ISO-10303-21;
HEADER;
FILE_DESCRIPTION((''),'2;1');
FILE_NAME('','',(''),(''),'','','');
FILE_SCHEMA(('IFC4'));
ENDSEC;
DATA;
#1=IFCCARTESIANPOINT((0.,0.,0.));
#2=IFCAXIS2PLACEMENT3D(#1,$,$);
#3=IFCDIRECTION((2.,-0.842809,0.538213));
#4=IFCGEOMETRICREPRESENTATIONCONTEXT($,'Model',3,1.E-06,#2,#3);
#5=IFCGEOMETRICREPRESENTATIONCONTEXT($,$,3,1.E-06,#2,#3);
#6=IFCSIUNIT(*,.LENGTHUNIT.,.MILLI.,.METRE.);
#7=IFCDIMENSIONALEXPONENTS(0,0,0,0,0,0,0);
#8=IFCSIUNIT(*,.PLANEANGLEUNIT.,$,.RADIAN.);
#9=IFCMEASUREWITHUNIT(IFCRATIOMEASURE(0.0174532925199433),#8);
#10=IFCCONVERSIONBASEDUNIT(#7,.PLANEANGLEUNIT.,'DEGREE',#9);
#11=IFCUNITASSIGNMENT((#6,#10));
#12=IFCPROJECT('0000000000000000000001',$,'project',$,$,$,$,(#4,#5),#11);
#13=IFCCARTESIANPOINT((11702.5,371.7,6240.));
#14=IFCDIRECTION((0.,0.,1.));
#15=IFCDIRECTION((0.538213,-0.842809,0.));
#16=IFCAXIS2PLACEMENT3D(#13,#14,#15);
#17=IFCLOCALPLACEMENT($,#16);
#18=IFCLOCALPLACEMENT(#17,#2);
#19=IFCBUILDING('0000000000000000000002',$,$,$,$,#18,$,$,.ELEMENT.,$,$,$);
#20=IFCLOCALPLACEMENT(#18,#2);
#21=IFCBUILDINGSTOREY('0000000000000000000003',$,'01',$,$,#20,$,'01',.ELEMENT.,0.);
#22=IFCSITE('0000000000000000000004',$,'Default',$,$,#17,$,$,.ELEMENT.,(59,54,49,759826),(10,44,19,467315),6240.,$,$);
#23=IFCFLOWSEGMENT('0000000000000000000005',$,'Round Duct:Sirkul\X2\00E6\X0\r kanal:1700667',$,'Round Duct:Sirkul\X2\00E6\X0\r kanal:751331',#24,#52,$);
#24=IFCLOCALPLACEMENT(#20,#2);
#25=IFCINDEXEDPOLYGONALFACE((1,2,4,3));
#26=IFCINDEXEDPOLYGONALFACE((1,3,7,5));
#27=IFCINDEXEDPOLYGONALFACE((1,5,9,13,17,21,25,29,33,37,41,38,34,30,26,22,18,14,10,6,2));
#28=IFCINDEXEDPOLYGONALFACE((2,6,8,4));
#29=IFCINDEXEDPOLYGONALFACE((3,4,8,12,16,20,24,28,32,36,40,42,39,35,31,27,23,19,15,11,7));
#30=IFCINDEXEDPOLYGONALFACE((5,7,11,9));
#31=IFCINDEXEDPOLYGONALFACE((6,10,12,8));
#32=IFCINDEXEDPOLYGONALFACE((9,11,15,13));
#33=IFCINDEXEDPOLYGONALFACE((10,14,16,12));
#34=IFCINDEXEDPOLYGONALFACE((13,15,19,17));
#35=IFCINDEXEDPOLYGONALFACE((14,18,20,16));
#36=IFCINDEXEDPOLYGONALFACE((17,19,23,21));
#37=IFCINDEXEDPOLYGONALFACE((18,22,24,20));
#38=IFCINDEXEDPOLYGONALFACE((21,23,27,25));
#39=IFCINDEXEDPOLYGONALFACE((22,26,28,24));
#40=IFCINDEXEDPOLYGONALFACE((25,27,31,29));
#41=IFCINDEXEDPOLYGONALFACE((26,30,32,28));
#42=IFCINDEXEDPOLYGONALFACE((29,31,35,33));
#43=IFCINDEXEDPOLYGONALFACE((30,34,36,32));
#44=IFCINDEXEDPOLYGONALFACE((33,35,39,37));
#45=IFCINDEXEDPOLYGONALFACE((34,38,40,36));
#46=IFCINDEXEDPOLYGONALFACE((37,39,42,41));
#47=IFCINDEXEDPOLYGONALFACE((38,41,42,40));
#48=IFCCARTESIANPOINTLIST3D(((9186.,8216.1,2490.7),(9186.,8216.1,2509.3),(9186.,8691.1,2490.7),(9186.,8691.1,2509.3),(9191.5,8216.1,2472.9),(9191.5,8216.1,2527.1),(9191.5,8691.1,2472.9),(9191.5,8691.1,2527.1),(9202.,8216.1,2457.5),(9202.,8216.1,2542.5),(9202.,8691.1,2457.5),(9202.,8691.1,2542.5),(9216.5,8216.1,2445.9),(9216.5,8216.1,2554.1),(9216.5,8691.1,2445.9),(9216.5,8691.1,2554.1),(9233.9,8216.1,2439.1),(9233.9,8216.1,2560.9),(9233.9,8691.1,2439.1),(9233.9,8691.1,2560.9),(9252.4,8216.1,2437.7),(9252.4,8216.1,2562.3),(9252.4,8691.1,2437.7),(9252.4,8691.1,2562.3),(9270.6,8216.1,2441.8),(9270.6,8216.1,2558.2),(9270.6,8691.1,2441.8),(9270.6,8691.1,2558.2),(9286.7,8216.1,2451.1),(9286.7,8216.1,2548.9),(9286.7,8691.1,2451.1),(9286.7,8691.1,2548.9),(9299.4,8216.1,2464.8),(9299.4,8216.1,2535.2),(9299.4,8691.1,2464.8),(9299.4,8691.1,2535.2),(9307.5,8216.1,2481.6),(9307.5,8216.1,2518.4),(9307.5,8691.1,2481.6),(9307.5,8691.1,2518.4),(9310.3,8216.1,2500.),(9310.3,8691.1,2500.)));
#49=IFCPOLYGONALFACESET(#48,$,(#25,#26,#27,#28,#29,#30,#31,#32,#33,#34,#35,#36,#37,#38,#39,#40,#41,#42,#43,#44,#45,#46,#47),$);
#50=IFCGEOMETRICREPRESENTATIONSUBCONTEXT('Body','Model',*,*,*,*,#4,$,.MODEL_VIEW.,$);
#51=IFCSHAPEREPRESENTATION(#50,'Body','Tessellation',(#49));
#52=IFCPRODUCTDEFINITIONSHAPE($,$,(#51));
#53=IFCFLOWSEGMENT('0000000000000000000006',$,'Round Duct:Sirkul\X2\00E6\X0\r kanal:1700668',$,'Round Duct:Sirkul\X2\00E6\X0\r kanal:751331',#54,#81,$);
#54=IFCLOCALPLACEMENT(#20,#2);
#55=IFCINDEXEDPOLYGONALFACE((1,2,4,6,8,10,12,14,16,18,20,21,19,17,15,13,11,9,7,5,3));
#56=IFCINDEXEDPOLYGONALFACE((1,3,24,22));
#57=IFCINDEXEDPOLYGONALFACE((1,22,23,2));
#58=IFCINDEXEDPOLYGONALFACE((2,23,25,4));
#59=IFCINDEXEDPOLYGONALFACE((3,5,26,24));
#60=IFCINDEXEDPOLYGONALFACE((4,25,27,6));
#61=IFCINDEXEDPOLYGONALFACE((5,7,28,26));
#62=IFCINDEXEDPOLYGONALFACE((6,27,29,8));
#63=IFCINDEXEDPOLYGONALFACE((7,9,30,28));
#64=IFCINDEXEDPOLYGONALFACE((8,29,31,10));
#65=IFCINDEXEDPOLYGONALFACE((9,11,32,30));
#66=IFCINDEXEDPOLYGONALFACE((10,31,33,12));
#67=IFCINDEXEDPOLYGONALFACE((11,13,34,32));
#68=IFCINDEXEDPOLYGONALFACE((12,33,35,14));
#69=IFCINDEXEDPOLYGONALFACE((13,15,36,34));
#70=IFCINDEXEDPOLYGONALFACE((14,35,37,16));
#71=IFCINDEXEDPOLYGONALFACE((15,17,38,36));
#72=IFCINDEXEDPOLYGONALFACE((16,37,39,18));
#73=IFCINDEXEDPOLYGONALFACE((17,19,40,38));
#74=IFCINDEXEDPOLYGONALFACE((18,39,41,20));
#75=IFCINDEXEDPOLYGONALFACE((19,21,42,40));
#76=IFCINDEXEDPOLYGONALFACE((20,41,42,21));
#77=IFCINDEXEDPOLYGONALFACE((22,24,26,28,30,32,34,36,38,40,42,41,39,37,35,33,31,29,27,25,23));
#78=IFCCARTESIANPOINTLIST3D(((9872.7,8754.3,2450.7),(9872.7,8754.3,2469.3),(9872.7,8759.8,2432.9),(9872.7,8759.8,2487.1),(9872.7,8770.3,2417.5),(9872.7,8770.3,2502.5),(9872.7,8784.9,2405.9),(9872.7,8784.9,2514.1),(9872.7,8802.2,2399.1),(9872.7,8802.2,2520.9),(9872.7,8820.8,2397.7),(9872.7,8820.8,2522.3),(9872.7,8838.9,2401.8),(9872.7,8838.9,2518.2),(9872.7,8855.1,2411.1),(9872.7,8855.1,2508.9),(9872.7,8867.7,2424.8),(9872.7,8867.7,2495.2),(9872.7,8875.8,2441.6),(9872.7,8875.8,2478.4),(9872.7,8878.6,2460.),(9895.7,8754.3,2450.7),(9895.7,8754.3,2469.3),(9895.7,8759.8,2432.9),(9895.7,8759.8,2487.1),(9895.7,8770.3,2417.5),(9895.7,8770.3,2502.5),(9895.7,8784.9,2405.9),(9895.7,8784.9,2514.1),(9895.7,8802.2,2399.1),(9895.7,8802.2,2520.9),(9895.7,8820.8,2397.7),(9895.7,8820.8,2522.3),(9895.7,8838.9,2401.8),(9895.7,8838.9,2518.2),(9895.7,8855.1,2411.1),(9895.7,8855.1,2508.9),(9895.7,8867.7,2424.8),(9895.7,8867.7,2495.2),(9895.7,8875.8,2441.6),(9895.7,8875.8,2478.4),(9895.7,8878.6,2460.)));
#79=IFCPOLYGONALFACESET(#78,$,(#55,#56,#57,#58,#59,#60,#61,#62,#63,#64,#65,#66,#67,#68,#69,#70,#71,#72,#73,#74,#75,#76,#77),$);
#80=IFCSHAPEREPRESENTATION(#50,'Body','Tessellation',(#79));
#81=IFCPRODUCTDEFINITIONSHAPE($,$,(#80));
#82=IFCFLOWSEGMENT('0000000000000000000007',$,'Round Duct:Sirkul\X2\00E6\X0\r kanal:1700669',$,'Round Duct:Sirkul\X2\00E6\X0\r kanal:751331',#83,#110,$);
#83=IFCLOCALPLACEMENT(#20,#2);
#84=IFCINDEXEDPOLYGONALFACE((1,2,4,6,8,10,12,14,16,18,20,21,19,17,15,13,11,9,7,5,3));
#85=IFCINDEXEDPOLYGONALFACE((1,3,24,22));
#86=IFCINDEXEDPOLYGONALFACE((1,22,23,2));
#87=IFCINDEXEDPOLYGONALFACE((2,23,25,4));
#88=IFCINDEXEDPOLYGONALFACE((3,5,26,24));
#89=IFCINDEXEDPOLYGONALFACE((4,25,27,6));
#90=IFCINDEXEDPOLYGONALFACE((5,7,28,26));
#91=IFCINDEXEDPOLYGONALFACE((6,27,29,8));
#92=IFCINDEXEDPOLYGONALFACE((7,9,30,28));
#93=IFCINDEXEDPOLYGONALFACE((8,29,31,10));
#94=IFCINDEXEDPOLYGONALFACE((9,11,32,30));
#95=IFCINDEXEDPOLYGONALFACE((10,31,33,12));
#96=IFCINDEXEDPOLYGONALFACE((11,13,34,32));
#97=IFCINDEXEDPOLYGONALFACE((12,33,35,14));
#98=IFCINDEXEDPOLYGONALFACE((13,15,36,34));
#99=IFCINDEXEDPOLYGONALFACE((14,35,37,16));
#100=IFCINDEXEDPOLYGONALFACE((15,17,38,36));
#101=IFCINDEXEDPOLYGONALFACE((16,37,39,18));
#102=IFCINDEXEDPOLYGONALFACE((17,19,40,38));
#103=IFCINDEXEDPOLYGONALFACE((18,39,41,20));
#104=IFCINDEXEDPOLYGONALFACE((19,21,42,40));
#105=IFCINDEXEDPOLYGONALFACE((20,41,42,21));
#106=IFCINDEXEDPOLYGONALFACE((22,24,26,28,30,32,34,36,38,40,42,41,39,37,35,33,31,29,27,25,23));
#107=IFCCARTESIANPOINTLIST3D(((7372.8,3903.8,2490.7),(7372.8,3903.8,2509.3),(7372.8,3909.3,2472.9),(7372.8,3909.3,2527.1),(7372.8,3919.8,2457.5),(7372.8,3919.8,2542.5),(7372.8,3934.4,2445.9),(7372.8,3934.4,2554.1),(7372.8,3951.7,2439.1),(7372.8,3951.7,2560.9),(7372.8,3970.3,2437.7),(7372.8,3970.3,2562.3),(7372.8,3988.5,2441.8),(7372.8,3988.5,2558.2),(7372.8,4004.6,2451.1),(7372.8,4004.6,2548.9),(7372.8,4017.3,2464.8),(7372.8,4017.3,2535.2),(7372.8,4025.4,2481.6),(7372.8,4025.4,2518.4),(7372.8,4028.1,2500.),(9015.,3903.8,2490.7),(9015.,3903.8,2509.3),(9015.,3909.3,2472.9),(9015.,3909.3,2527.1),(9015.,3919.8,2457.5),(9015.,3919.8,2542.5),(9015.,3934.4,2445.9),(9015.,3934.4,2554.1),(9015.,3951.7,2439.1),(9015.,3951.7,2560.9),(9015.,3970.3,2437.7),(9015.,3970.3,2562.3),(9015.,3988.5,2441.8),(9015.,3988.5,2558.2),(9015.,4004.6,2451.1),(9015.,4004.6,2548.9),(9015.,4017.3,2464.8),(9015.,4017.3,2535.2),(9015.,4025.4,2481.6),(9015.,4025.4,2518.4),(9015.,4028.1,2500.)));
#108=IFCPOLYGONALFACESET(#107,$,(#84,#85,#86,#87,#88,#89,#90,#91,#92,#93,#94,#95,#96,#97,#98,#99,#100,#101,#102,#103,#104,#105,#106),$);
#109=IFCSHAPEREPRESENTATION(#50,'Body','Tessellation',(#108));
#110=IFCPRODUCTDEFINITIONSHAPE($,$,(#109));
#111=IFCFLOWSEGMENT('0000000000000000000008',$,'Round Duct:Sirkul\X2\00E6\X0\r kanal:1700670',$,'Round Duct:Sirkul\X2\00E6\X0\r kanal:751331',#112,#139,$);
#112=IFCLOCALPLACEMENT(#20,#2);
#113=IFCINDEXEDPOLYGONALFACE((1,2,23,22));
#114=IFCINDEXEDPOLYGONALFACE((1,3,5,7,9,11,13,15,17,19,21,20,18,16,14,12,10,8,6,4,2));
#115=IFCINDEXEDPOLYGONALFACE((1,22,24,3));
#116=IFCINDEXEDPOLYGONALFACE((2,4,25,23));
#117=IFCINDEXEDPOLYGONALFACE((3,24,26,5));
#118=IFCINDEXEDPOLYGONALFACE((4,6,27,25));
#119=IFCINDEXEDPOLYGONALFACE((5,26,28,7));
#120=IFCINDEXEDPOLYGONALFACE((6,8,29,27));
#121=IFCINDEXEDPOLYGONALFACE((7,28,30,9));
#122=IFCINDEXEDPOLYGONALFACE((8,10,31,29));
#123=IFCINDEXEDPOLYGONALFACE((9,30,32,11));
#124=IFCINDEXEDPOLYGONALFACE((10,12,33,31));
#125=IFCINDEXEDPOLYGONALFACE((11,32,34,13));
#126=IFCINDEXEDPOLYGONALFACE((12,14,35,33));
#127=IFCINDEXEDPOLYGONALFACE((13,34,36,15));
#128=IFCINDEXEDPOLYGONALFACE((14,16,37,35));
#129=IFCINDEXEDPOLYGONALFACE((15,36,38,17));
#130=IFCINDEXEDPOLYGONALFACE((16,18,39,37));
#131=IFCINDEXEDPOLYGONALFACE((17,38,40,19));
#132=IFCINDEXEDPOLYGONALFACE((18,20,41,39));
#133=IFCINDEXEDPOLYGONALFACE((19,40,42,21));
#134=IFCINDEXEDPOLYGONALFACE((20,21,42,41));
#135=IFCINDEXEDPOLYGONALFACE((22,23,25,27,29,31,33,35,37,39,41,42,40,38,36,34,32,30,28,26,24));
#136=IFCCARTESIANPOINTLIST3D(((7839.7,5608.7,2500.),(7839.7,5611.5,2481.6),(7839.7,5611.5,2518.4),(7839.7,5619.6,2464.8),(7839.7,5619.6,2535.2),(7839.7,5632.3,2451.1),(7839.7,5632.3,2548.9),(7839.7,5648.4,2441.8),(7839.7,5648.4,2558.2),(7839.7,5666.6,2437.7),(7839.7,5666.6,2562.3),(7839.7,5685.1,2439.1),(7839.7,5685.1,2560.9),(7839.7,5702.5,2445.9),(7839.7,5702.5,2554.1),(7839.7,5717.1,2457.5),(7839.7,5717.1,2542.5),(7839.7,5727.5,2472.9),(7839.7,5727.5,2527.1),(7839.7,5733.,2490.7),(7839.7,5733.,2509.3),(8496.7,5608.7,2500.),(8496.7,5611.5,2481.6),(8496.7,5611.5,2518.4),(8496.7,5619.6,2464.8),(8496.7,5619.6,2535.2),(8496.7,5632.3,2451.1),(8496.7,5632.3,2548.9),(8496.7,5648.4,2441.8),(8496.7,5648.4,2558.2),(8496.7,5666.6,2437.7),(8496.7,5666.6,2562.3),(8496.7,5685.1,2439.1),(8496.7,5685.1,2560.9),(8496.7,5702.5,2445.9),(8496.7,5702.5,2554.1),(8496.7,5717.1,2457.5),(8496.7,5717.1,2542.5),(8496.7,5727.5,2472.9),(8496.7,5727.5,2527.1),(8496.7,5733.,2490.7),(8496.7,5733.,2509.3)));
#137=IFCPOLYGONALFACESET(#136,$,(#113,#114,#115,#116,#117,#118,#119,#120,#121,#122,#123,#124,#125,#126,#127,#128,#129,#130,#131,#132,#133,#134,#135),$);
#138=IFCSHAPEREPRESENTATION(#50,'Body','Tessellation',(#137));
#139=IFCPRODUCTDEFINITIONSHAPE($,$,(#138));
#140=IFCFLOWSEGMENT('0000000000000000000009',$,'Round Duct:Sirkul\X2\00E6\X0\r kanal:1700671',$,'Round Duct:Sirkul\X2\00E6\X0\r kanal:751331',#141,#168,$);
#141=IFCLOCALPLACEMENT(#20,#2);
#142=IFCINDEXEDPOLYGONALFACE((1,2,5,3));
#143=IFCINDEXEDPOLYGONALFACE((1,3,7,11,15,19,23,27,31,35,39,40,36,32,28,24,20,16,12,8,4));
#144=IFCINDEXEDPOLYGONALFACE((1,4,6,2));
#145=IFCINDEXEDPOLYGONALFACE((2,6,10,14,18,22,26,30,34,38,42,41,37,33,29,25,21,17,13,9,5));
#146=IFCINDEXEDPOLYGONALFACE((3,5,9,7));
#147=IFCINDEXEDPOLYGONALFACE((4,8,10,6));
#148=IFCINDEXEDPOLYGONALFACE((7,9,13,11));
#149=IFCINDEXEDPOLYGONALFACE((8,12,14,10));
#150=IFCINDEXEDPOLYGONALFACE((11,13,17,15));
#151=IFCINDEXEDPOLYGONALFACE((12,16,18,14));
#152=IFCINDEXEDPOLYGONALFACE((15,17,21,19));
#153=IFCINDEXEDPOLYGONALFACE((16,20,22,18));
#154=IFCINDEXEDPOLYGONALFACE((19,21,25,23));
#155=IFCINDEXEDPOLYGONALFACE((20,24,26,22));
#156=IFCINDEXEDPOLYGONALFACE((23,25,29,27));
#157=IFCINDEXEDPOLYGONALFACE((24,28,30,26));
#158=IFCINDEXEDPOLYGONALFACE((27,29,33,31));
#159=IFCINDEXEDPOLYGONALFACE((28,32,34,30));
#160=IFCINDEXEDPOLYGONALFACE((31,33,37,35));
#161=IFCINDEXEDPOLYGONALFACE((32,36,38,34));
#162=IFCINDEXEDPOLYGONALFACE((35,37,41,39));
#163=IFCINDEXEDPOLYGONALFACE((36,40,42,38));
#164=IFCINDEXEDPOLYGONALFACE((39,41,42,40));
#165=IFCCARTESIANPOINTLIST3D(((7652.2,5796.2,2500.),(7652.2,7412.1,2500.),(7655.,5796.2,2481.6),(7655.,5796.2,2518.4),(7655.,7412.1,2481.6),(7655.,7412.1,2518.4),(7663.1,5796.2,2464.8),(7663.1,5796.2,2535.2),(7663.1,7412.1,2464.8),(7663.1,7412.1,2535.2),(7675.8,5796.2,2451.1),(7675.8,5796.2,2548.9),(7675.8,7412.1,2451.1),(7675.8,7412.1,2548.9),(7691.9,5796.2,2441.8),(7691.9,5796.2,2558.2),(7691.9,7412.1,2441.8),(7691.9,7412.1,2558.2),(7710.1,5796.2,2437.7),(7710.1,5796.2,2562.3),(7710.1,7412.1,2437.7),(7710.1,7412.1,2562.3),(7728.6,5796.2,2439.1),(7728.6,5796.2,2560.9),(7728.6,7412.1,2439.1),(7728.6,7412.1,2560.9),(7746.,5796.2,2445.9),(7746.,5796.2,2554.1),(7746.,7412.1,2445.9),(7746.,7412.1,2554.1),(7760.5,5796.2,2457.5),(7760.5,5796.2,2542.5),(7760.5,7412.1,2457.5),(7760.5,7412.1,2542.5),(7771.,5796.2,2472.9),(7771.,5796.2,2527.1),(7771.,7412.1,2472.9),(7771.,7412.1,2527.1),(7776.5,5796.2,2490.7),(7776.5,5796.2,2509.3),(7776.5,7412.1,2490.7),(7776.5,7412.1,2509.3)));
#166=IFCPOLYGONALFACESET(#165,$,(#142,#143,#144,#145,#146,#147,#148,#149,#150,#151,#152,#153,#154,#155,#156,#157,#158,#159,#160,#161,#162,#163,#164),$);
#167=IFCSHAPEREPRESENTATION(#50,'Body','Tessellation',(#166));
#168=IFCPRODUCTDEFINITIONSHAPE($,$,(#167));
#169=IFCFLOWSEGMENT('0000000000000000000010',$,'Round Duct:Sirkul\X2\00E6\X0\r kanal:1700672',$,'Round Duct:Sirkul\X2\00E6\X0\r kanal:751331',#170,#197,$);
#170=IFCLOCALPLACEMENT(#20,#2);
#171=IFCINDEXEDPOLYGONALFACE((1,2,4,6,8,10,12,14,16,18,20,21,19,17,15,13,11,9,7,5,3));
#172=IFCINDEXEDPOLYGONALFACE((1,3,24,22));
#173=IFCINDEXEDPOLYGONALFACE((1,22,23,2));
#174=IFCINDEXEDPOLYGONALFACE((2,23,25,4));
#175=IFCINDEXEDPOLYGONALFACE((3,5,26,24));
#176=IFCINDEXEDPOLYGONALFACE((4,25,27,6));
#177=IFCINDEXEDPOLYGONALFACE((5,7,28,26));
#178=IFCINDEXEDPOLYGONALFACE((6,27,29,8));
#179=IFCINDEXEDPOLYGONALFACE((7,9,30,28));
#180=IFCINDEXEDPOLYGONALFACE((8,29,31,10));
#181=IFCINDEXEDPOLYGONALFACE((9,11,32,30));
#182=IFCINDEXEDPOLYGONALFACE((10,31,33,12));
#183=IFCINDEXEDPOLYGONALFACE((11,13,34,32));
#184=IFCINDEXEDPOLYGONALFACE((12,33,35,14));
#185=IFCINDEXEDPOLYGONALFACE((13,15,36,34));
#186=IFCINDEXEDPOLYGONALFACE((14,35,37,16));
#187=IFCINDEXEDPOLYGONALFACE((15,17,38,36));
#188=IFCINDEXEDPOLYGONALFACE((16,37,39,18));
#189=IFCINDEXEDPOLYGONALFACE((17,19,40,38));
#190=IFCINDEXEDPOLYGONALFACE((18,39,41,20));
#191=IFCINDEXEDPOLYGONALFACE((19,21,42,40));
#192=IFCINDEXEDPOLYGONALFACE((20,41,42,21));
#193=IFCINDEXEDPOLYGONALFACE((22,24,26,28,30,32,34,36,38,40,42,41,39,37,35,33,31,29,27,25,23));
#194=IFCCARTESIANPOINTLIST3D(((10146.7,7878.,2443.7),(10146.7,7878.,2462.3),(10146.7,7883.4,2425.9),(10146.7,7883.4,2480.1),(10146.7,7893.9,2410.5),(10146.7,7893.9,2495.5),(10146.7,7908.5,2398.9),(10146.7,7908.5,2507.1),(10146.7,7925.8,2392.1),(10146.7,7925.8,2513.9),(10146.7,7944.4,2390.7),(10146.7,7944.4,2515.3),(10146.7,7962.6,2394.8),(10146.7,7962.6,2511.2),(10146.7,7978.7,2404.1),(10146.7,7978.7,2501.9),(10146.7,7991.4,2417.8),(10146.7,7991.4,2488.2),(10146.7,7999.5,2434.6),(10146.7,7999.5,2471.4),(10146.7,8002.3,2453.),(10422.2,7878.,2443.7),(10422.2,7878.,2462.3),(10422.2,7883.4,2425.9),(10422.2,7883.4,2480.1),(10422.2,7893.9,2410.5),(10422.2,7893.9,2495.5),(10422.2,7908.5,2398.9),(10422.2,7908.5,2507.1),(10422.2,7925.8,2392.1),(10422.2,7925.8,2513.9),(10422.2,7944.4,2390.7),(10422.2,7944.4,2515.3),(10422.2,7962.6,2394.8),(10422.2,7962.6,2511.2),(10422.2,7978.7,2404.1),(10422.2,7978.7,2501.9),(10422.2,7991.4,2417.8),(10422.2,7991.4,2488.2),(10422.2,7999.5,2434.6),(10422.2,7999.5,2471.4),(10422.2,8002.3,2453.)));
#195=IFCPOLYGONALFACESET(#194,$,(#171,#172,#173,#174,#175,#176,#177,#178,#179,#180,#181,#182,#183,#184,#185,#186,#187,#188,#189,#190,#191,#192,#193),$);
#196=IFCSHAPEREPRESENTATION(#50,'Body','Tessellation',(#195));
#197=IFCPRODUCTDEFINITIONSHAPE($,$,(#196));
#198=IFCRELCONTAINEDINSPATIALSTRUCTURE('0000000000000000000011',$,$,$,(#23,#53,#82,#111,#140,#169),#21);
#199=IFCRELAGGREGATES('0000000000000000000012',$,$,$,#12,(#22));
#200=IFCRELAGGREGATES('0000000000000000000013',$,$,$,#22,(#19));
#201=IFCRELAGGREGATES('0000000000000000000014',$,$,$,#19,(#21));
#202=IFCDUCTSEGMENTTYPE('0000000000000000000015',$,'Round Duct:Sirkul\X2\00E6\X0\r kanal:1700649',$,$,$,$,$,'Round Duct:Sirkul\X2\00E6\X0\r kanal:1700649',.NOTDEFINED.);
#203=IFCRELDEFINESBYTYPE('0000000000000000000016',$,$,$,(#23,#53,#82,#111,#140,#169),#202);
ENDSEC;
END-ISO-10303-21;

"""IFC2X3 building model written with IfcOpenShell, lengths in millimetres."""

from ifc_helpers import new_model, entity, si_unit, converted_unit, direction, frame, frame_2d, origin, origin_2d_with_axis, place, context, subcontext, project, spatial, circle, extrude, type_object, element, save


model = new_model("IFC2X3")

# Units and contexts
model_context = context("Model", 3, precision=1e-06, world=origin(), true_north=direction((2.0, -0.842809, 0.538213)))
context_of_model = context(None, 3, precision=1e-06, world=origin(), true_north=direction((2.0, -0.842809, 0.538213)))
body_context = subcontext(model_context, "Body", "Model", "MODEL_VIEW")
ifc_project = project(units=[si_unit("LENGTHUNIT", "METRE", prefix="MILLI"), converted_unit("PLANEANGLEUNIT", "DEGREE", entity("IfcRatioMeasure", 0.0174532925199433), si_unit("PLANEANGLEUNIT", "RADIAN"), dimensions=[0, 0, 0, 0, 0, 0, 0])], contexts=[model_context, context_of_model])

# Site, building, storey
site_placement = place(None, frame((11702.5, 371.7, 6240.0), z_axis=(0.0, 0.0, 1.0), x_axis=(0.538213, -0.842809, 0.0)))
site = spatial("IfcSite", under=ifc_project, at=site_placement, Name="Default", CompositionType="ELEMENT", RefLatitude=(59, 54, 49, 759826), RefLongitude=(10, 44, 19, 467315), RefElevation=6240.0)
building_placement = place(site_placement, origin())
building = spatial("IfcBuilding", under=site, at=building_placement, CompositionType="ELEMENT")
storey_placement = place(building_placement, origin())
storey = spatial("IfcBuildingStorey", under=building, at=storey_placement, Name="01", LongName="01", CompositionType="ELEMENT", Elevation=0.0)

# Flow segments
duct_segment_type = type_object("IfcDuctSegmentType", Name="Round Duct:Sirkulær kanal:1700649", ElementType="Round Duct:Sirkulær kanal:1700649", PredefinedType="NOTDEFINED")
flow_segment_1_placement = place(storey_placement, origin())
element("IfcFlowSegment", 1, at=flow_segment_1_placement, inside=storey, type_object=duct_segment_type, Name="Round Duct:Sirkulær kanal:1700667", ObjectType="Round Duct:Sirkulær kanal:751331", context=body_context, shape_type="SweptSolid", body=[
    extrude(circle(Radius=62.5, at=origin_2d_with_axis()), frame((9247.8, 8216.1, 2500.0), z_axis=(0.0, 1.0, 0.0), x_axis=(1.0, 0.0, 0.0)), (0.0, 0.0, 1.0), 475.0),
])
flow_segment_2_placement = place(storey_placement, origin())
element("IfcFlowSegment", 2, at=flow_segment_2_placement, inside=storey, type_object=duct_segment_type, Name="Round Duct:Sirkulær kanal:1700668", ObjectType="Round Duct:Sirkulær kanal:751331", context=body_context, shape_type="SweptSolid", body=[
    extrude(circle(Radius=62.5, at=frame_2d((0.0, 0.0), x_axis=(1.0, 0.0))), frame((9872.7, 8816.1, 2460.0), z_axis=(1.0, 0.0, 0.0), x_axis=(0.0, 1.0, 0.0)), (0.0, 0.0, 1.0), 23.1),
])
flow_segment_3_placement = place(storey_placement, origin())
element("IfcFlowSegment", 3, at=flow_segment_3_placement, inside=storey, type_object=duct_segment_type, Name="Round Duct:Sirkulær kanal:1700669", ObjectType="Round Duct:Sirkulær kanal:751331", context=body_context, shape_type="SweptSolid", body=[
    extrude(circle(Radius=62.5, at=frame_2d((0.0, 0.0), x_axis=(1.0, 0.0))), frame((7372.8, 3965.6, 2500.0), z_axis=(1.0, 0.0, 0.0), x_axis=(0.0, 1.0, 0.0)), (0.0, 0.0, 1.0), 1642.2),
])
flow_segment_4_placement = place(storey_placement, origin())
element("IfcFlowSegment", 4, at=flow_segment_4_placement, inside=storey, type_object=duct_segment_type, Name="Round Duct:Sirkulær kanal:1700670", ObjectType="Round Duct:Sirkulær kanal:751331", context=body_context, shape_type="SweptSolid", body=[
    extrude(circle(Radius=62.5, at=origin_2d_with_axis()), frame((7839.7, 5671.2, 2500.0), z_axis=(1.0, 0.0, 0.0), x_axis=(0.0, -1.0, 0.0)), (0.0, 0.0, 1.0), 657.0),
])
flow_segment_5_placement = place(storey_placement, origin())
element("IfcFlowSegment", 5, at=flow_segment_5_placement, inside=storey, type_object=duct_segment_type, Name="Round Duct:Sirkulær kanal:1700671", ObjectType="Round Duct:Sirkulær kanal:751331", context=body_context, shape_type="SweptSolid", body=[
    extrude(circle(Radius=62.5, at=frame_2d((0.0, 0.0), x_axis=(1.0, 0.0))), frame((7714.7, 5796.2, 2500.0), z_axis=(0.0, 1.0, 0.0), x_axis=(-1.0, 0.0, 0.0)), (0.0, 0.0, 1.0), 1615.9),
])
flow_segment_6_placement = place(storey_placement, origin())
element("IfcFlowSegment", 6, at=flow_segment_6_placement, inside=storey, type_object=duct_segment_type, Name="Round Duct:Sirkulær kanal:1700672", ObjectType="Round Duct:Sirkulær kanal:751331", context=body_context, shape_type="SweptSolid", body=[
    extrude(circle(Radius=62.5, at=origin_2d_with_axis()), frame((10146.7, 7939.8, 2453.0), z_axis=(1.0, 0.0, 0.0), x_axis=(0.0, 1.0, 0.0)), (0.0, 0.0, 1.0), 275.5),
])

save(model, "model.ifc")
